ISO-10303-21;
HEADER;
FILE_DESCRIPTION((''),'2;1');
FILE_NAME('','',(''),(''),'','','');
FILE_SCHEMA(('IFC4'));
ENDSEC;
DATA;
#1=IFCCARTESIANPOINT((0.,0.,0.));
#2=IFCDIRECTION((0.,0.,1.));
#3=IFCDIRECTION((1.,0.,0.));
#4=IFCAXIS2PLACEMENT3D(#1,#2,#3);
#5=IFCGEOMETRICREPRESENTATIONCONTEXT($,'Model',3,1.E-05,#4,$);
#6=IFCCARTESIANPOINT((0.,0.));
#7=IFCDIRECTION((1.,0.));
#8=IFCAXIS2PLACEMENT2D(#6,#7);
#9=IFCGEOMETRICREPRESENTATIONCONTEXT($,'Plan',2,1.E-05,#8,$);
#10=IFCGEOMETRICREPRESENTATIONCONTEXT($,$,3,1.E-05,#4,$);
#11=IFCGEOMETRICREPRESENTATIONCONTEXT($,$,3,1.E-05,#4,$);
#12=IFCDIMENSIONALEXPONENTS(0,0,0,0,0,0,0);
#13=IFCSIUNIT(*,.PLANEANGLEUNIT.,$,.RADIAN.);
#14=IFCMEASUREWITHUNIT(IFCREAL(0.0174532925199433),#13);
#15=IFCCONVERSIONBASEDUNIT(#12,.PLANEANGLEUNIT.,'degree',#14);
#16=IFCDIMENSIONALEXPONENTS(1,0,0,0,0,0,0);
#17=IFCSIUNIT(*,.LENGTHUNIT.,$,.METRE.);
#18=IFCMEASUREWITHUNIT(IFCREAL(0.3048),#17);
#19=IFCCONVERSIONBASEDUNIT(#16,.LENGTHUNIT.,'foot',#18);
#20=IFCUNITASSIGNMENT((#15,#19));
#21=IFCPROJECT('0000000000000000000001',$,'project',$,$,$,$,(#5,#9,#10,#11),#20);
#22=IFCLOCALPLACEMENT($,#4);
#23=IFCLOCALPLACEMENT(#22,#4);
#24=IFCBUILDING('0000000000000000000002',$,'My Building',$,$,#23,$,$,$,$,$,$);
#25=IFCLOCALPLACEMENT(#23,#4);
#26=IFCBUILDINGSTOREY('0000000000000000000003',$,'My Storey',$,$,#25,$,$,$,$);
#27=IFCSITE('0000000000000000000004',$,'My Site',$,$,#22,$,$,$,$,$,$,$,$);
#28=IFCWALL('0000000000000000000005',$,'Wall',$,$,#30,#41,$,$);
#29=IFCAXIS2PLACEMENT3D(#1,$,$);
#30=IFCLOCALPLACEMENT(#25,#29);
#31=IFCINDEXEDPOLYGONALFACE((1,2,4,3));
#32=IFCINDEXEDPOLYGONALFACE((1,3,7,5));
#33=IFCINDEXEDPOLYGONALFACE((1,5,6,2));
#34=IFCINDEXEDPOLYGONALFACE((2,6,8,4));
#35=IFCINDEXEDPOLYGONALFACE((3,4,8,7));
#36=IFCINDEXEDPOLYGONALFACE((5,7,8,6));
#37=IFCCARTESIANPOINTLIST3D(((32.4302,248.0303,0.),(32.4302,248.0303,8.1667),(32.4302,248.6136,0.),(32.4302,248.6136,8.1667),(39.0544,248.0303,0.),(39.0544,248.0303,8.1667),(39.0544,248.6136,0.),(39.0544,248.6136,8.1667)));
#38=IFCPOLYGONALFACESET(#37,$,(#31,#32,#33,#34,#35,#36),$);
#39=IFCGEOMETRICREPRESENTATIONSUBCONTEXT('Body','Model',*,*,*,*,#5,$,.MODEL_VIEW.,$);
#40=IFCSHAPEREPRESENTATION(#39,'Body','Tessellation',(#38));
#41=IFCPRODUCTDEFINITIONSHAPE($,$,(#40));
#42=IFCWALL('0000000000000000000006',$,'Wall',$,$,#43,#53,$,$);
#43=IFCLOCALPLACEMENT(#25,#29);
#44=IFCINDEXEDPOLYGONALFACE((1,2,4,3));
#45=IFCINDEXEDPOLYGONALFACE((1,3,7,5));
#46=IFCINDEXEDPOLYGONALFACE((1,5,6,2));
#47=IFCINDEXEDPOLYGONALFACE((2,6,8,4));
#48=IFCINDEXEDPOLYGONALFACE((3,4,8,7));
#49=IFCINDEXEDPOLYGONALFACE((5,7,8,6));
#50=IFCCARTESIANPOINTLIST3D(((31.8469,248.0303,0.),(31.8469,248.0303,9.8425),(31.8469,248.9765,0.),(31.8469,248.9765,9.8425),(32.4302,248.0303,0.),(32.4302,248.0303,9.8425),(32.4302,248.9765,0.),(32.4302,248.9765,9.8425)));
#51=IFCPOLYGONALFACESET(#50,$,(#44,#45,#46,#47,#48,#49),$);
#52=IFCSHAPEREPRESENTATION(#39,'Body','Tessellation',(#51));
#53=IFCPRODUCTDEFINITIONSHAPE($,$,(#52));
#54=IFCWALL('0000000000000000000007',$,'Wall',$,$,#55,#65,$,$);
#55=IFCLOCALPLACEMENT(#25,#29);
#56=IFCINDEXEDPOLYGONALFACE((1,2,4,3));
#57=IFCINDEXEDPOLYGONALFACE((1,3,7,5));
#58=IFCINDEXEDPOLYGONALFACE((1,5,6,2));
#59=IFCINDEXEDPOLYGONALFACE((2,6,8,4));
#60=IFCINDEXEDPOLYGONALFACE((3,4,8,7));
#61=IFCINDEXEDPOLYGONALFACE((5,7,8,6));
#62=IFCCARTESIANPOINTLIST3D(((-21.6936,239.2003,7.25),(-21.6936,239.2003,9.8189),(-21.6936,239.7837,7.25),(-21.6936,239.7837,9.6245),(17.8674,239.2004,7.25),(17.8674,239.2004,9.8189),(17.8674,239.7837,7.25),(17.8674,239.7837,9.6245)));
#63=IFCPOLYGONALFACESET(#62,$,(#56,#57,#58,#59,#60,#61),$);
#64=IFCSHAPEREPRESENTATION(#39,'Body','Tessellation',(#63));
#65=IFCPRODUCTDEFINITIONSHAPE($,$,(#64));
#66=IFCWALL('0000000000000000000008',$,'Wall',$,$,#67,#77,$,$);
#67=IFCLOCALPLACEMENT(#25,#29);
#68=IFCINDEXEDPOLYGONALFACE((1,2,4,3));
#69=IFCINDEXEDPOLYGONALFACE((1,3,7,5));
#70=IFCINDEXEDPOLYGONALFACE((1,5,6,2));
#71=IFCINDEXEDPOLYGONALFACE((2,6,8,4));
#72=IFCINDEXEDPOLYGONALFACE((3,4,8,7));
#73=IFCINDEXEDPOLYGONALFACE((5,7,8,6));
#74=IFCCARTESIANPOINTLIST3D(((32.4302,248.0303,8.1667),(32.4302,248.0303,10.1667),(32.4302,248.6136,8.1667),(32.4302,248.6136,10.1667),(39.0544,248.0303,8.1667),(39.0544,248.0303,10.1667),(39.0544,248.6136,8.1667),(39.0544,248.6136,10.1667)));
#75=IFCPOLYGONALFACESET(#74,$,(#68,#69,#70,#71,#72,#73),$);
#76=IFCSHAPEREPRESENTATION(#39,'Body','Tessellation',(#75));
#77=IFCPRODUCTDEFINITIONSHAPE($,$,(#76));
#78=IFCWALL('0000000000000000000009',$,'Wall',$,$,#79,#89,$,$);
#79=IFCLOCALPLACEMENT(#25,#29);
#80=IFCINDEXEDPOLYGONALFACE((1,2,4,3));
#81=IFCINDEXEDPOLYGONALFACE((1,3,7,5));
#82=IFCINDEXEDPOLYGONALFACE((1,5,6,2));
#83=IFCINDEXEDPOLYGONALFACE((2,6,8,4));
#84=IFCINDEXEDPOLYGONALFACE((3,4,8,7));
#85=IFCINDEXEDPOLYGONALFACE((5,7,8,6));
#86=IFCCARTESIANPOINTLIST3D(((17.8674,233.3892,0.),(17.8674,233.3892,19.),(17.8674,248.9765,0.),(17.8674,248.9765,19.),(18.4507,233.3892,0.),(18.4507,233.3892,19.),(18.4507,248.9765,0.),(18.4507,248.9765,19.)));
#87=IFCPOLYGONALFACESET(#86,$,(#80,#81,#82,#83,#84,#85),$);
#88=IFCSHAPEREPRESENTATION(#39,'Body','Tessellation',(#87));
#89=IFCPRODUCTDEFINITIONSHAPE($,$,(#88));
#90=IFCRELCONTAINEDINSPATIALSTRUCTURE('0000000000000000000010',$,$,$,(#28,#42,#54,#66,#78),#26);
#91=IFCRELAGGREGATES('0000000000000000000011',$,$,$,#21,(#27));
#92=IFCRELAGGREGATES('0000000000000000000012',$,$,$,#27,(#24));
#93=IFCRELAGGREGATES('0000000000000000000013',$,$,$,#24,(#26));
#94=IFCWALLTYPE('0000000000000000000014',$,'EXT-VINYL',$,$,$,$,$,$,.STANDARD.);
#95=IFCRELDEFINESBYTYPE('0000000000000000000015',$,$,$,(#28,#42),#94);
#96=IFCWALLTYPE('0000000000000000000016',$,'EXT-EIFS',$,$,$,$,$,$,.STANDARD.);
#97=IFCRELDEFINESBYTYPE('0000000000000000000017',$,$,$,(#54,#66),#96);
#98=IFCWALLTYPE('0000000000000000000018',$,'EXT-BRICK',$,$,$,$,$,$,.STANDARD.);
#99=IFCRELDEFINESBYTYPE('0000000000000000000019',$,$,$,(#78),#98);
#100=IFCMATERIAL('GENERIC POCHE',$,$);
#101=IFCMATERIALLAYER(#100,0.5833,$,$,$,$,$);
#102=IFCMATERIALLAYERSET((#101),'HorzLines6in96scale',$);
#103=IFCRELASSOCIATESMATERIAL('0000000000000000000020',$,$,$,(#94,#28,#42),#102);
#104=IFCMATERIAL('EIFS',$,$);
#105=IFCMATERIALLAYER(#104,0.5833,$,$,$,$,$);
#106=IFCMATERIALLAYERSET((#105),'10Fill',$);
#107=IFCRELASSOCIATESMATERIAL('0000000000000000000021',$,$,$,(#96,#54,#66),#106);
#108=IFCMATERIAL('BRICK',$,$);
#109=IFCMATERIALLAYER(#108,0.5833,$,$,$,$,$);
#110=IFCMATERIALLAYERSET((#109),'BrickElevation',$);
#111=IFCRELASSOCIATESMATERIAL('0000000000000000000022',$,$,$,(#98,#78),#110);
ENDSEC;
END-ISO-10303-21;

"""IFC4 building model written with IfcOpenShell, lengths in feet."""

from ifc_helpers import new_model, entity, si_unit, converted_unit, frame, origin_with_axes, origin_2d_with_axis, place, context, subcontext, project, spatial, indexed_curve, outline, extrude, clip, halfspace, material, layer, layer_set, layer_usage, type_object, element, save


model = new_model("IFC4")

# Units and contexts
model_context = context("Model", 3, precision=1e-05, world=origin_with_axes())
plan_context = context("Plan", 2, precision=1e-05, world=origin_2d_with_axis())
context_of_model_1 = context(None, 3, precision=1e-05, world=origin_with_axes())
context_of_model_2 = context(None, 3, precision=1e-05, world=origin_with_axes())
body_context = subcontext(model_context, "Body", "Model", "MODEL_VIEW")
ifc_project = project(units=[converted_unit("PLANEANGLEUNIT", "degree", entity("IfcReal", 0.0174532925199433), si_unit("PLANEANGLEUNIT", "RADIAN"), dimensions=[0, 0, 0, 0, 0, 0, 0]), converted_unit("LENGTHUNIT", "foot", entity("IfcReal", 0.3048), si_unit("LENGTHUNIT", "METRE"), dimensions=[1, 0, 0, 0, 0, 0, 0])], contexts=[model_context, plan_context, context_of_model_1, context_of_model_2])

# Site, building, storey
site_placement = place(None, origin_with_axes())
site = spatial("IfcSite", under=ifc_project, at=site_placement, Name="My Site")
building_placement = place(site_placement, origin_with_axes())
building = spatial("IfcBuilding", under=site, at=building_placement, Name="My Building")
storey_placement = place(building_placement, origin_with_axes())
storey = spatial("IfcBuildingStorey", under=building, at=storey_placement, Name="My Storey")

# Walls
ifc_material_1 = material(Name="GENERIC POCHE")
ifc_layer_1 = layer(ifc_material_1, 0.5833)
ifc_layer_set_1 = layer_set([ifc_layer_1], Name="HorzLines6in96scale")
ifc_layer_usage_1 = layer_usage(ifc_layer_set_1, "AXIS2", "POSITIVE", 0.0)
wall_type_1 = type_object("IfcWallType", Name="EXT-VINYL", PredefinedType="STANDARD", material=ifc_layer_set_1)
wall_1_placement = place(storey_placement, frame((32.4302, 248.0303, 0.0), z_axis=(0.0, 0.0, 1.0), x_axis=(1.0, 0.0, 0.0)))
element("IfcWall", 1, at=wall_1_placement, inside=storey, type_object=wall_type_1, material=ifc_layer_usage_1, Name="Wall", context=body_context, shape_type="SweptSolid", body=[
    extrude(outline(indexed_curve([(0.0, 0.0), (0.0, 0.5833), (6.6242, 0.5833), (6.6242, 0.0), (0.0, 0.0)], self_intersect=False)), origin_with_axes(), (0.0, 0.0, 1.0), 8.1667),
])
ifc_layer_usage_2 = layer_usage(ifc_layer_set_1, "AXIS2", "POSITIVE", 0.0)
wall_2_placement = place(storey_placement, frame((31.8469, 248.9765, 0.0), z_axis=(0.0, 0.0, 1.0), x_axis=(0.0, -1.0, 0.0)))
element("IfcWall", 2, at=wall_2_placement, inside=storey, type_object=wall_type_1, material=ifc_layer_usage_2, Name="Wall", context=body_context, shape_type="SweptSolid", body=[
    extrude(outline(indexed_curve([(0.0, 0.0), (0.0, 0.5833), (0.9462, 0.5833), (0.9462, 0.0), (0.0, 0.0)], self_intersect=False)), origin_with_axes(), (0.0, 0.0, 1.0), 9.8425),
])

# Shared definitions
ifc_material_2 = material(Name="EIFS")
ifc_layer_2 = layer(ifc_material_2, 0.5833)
ifc_layer_set_2 = layer_set([ifc_layer_2], Name="10Fill")
wall_type_2 = type_object("IfcWallType", Name="EXT-EIFS", PredefinedType="STANDARD", material=ifc_layer_set_2)

# Walls
ifc_layer_usage_3 = layer_usage(ifc_layer_set_2, "AXIS2", "POSITIVE", 0.0)
wall_3_placement = place(storey_placement, frame((17.8674, 239.7837, 7.25), z_axis=(0.0, 0.0, 1.0), x_axis=(-1.0, 0.0, 0.0)))
element("IfcWall", 3, at=wall_3_placement, inside=storey, type_object=wall_type_2, material=ifc_layer_usage_3, Name="Wall", context=body_context, shape_type="Clipping", body=[
    clip(extrude(outline(indexed_curve([(0.0, 0.0), (0.0, 0.5833), (39.561, 0.5833), (39.561, 0.0), (0.0, 0.0)], self_intersect=False)), origin_with_axes(), (0.0, 0.0, 1.0), 9.8189), halfspace(frame((0.0, 0.5834, 2.5689), z_axis=(0.0, -0.316146, 0.948711), x_axis=(1.0, 0.0, 0.0)), False)),
])
ifc_layer_usage_4 = layer_usage(ifc_layer_set_2, "AXIS2", "POSITIVE", 0.0)
wall_4_placement = place(storey_placement, frame((32.4302, 248.0303, 8.1667), z_axis=(0.0, 0.0, 1.0), x_axis=(1.0, 0.0, 0.0)))
element("IfcWall", 4, at=wall_4_placement, inside=storey, type_object=wall_type_2, material=ifc_layer_usage_4, Name="Wall", context=body_context, shape_type="SweptSolid", body=[
    extrude(outline(indexed_curve([(0.0, 0.0), (0.0, 0.5833), (6.6242, 0.5833), (6.6242, 0.0), (0.0, 0.0)], self_intersect=False)), origin_with_axes(), (0.0, 0.0, 1.0), 2.0),
])
ifc_material_3 = material(Name="BRICK")
ifc_layer_3 = layer(ifc_material_3, 0.5833)
ifc_layer_set_3 = layer_set([ifc_layer_3], Name="BrickElevation")
ifc_layer_usage_5 = layer_usage(ifc_layer_set_3, "AXIS2", "POSITIVE", 0.0)
wall_type_3 = type_object("IfcWallType", Name="EXT-BRICK", PredefinedType="STANDARD", material=ifc_layer_set_3)
wall_5_placement = place(storey_placement, frame((18.4507, 233.3892, 0.0), z_axis=(0.0, 0.0, 1.0), x_axis=(0.0, 1.0, 0.0)))
element("IfcWall", 5, at=wall_5_placement, inside=storey, type_object=wall_type_3, material=ifc_layer_usage_5, Name="Wall", context=body_context, shape_type="SweptSolid", body=[
    extrude(outline(indexed_curve([(0.0, 0.0), (0.0, 0.5833), (15.5873, 0.5833), (15.5873, 0.0), (0.0, 0.0)], self_intersect=False)), origin_with_axes(), (0.0, 0.0, 1.0), 19.0),
])

save(model, "model.ifc")
